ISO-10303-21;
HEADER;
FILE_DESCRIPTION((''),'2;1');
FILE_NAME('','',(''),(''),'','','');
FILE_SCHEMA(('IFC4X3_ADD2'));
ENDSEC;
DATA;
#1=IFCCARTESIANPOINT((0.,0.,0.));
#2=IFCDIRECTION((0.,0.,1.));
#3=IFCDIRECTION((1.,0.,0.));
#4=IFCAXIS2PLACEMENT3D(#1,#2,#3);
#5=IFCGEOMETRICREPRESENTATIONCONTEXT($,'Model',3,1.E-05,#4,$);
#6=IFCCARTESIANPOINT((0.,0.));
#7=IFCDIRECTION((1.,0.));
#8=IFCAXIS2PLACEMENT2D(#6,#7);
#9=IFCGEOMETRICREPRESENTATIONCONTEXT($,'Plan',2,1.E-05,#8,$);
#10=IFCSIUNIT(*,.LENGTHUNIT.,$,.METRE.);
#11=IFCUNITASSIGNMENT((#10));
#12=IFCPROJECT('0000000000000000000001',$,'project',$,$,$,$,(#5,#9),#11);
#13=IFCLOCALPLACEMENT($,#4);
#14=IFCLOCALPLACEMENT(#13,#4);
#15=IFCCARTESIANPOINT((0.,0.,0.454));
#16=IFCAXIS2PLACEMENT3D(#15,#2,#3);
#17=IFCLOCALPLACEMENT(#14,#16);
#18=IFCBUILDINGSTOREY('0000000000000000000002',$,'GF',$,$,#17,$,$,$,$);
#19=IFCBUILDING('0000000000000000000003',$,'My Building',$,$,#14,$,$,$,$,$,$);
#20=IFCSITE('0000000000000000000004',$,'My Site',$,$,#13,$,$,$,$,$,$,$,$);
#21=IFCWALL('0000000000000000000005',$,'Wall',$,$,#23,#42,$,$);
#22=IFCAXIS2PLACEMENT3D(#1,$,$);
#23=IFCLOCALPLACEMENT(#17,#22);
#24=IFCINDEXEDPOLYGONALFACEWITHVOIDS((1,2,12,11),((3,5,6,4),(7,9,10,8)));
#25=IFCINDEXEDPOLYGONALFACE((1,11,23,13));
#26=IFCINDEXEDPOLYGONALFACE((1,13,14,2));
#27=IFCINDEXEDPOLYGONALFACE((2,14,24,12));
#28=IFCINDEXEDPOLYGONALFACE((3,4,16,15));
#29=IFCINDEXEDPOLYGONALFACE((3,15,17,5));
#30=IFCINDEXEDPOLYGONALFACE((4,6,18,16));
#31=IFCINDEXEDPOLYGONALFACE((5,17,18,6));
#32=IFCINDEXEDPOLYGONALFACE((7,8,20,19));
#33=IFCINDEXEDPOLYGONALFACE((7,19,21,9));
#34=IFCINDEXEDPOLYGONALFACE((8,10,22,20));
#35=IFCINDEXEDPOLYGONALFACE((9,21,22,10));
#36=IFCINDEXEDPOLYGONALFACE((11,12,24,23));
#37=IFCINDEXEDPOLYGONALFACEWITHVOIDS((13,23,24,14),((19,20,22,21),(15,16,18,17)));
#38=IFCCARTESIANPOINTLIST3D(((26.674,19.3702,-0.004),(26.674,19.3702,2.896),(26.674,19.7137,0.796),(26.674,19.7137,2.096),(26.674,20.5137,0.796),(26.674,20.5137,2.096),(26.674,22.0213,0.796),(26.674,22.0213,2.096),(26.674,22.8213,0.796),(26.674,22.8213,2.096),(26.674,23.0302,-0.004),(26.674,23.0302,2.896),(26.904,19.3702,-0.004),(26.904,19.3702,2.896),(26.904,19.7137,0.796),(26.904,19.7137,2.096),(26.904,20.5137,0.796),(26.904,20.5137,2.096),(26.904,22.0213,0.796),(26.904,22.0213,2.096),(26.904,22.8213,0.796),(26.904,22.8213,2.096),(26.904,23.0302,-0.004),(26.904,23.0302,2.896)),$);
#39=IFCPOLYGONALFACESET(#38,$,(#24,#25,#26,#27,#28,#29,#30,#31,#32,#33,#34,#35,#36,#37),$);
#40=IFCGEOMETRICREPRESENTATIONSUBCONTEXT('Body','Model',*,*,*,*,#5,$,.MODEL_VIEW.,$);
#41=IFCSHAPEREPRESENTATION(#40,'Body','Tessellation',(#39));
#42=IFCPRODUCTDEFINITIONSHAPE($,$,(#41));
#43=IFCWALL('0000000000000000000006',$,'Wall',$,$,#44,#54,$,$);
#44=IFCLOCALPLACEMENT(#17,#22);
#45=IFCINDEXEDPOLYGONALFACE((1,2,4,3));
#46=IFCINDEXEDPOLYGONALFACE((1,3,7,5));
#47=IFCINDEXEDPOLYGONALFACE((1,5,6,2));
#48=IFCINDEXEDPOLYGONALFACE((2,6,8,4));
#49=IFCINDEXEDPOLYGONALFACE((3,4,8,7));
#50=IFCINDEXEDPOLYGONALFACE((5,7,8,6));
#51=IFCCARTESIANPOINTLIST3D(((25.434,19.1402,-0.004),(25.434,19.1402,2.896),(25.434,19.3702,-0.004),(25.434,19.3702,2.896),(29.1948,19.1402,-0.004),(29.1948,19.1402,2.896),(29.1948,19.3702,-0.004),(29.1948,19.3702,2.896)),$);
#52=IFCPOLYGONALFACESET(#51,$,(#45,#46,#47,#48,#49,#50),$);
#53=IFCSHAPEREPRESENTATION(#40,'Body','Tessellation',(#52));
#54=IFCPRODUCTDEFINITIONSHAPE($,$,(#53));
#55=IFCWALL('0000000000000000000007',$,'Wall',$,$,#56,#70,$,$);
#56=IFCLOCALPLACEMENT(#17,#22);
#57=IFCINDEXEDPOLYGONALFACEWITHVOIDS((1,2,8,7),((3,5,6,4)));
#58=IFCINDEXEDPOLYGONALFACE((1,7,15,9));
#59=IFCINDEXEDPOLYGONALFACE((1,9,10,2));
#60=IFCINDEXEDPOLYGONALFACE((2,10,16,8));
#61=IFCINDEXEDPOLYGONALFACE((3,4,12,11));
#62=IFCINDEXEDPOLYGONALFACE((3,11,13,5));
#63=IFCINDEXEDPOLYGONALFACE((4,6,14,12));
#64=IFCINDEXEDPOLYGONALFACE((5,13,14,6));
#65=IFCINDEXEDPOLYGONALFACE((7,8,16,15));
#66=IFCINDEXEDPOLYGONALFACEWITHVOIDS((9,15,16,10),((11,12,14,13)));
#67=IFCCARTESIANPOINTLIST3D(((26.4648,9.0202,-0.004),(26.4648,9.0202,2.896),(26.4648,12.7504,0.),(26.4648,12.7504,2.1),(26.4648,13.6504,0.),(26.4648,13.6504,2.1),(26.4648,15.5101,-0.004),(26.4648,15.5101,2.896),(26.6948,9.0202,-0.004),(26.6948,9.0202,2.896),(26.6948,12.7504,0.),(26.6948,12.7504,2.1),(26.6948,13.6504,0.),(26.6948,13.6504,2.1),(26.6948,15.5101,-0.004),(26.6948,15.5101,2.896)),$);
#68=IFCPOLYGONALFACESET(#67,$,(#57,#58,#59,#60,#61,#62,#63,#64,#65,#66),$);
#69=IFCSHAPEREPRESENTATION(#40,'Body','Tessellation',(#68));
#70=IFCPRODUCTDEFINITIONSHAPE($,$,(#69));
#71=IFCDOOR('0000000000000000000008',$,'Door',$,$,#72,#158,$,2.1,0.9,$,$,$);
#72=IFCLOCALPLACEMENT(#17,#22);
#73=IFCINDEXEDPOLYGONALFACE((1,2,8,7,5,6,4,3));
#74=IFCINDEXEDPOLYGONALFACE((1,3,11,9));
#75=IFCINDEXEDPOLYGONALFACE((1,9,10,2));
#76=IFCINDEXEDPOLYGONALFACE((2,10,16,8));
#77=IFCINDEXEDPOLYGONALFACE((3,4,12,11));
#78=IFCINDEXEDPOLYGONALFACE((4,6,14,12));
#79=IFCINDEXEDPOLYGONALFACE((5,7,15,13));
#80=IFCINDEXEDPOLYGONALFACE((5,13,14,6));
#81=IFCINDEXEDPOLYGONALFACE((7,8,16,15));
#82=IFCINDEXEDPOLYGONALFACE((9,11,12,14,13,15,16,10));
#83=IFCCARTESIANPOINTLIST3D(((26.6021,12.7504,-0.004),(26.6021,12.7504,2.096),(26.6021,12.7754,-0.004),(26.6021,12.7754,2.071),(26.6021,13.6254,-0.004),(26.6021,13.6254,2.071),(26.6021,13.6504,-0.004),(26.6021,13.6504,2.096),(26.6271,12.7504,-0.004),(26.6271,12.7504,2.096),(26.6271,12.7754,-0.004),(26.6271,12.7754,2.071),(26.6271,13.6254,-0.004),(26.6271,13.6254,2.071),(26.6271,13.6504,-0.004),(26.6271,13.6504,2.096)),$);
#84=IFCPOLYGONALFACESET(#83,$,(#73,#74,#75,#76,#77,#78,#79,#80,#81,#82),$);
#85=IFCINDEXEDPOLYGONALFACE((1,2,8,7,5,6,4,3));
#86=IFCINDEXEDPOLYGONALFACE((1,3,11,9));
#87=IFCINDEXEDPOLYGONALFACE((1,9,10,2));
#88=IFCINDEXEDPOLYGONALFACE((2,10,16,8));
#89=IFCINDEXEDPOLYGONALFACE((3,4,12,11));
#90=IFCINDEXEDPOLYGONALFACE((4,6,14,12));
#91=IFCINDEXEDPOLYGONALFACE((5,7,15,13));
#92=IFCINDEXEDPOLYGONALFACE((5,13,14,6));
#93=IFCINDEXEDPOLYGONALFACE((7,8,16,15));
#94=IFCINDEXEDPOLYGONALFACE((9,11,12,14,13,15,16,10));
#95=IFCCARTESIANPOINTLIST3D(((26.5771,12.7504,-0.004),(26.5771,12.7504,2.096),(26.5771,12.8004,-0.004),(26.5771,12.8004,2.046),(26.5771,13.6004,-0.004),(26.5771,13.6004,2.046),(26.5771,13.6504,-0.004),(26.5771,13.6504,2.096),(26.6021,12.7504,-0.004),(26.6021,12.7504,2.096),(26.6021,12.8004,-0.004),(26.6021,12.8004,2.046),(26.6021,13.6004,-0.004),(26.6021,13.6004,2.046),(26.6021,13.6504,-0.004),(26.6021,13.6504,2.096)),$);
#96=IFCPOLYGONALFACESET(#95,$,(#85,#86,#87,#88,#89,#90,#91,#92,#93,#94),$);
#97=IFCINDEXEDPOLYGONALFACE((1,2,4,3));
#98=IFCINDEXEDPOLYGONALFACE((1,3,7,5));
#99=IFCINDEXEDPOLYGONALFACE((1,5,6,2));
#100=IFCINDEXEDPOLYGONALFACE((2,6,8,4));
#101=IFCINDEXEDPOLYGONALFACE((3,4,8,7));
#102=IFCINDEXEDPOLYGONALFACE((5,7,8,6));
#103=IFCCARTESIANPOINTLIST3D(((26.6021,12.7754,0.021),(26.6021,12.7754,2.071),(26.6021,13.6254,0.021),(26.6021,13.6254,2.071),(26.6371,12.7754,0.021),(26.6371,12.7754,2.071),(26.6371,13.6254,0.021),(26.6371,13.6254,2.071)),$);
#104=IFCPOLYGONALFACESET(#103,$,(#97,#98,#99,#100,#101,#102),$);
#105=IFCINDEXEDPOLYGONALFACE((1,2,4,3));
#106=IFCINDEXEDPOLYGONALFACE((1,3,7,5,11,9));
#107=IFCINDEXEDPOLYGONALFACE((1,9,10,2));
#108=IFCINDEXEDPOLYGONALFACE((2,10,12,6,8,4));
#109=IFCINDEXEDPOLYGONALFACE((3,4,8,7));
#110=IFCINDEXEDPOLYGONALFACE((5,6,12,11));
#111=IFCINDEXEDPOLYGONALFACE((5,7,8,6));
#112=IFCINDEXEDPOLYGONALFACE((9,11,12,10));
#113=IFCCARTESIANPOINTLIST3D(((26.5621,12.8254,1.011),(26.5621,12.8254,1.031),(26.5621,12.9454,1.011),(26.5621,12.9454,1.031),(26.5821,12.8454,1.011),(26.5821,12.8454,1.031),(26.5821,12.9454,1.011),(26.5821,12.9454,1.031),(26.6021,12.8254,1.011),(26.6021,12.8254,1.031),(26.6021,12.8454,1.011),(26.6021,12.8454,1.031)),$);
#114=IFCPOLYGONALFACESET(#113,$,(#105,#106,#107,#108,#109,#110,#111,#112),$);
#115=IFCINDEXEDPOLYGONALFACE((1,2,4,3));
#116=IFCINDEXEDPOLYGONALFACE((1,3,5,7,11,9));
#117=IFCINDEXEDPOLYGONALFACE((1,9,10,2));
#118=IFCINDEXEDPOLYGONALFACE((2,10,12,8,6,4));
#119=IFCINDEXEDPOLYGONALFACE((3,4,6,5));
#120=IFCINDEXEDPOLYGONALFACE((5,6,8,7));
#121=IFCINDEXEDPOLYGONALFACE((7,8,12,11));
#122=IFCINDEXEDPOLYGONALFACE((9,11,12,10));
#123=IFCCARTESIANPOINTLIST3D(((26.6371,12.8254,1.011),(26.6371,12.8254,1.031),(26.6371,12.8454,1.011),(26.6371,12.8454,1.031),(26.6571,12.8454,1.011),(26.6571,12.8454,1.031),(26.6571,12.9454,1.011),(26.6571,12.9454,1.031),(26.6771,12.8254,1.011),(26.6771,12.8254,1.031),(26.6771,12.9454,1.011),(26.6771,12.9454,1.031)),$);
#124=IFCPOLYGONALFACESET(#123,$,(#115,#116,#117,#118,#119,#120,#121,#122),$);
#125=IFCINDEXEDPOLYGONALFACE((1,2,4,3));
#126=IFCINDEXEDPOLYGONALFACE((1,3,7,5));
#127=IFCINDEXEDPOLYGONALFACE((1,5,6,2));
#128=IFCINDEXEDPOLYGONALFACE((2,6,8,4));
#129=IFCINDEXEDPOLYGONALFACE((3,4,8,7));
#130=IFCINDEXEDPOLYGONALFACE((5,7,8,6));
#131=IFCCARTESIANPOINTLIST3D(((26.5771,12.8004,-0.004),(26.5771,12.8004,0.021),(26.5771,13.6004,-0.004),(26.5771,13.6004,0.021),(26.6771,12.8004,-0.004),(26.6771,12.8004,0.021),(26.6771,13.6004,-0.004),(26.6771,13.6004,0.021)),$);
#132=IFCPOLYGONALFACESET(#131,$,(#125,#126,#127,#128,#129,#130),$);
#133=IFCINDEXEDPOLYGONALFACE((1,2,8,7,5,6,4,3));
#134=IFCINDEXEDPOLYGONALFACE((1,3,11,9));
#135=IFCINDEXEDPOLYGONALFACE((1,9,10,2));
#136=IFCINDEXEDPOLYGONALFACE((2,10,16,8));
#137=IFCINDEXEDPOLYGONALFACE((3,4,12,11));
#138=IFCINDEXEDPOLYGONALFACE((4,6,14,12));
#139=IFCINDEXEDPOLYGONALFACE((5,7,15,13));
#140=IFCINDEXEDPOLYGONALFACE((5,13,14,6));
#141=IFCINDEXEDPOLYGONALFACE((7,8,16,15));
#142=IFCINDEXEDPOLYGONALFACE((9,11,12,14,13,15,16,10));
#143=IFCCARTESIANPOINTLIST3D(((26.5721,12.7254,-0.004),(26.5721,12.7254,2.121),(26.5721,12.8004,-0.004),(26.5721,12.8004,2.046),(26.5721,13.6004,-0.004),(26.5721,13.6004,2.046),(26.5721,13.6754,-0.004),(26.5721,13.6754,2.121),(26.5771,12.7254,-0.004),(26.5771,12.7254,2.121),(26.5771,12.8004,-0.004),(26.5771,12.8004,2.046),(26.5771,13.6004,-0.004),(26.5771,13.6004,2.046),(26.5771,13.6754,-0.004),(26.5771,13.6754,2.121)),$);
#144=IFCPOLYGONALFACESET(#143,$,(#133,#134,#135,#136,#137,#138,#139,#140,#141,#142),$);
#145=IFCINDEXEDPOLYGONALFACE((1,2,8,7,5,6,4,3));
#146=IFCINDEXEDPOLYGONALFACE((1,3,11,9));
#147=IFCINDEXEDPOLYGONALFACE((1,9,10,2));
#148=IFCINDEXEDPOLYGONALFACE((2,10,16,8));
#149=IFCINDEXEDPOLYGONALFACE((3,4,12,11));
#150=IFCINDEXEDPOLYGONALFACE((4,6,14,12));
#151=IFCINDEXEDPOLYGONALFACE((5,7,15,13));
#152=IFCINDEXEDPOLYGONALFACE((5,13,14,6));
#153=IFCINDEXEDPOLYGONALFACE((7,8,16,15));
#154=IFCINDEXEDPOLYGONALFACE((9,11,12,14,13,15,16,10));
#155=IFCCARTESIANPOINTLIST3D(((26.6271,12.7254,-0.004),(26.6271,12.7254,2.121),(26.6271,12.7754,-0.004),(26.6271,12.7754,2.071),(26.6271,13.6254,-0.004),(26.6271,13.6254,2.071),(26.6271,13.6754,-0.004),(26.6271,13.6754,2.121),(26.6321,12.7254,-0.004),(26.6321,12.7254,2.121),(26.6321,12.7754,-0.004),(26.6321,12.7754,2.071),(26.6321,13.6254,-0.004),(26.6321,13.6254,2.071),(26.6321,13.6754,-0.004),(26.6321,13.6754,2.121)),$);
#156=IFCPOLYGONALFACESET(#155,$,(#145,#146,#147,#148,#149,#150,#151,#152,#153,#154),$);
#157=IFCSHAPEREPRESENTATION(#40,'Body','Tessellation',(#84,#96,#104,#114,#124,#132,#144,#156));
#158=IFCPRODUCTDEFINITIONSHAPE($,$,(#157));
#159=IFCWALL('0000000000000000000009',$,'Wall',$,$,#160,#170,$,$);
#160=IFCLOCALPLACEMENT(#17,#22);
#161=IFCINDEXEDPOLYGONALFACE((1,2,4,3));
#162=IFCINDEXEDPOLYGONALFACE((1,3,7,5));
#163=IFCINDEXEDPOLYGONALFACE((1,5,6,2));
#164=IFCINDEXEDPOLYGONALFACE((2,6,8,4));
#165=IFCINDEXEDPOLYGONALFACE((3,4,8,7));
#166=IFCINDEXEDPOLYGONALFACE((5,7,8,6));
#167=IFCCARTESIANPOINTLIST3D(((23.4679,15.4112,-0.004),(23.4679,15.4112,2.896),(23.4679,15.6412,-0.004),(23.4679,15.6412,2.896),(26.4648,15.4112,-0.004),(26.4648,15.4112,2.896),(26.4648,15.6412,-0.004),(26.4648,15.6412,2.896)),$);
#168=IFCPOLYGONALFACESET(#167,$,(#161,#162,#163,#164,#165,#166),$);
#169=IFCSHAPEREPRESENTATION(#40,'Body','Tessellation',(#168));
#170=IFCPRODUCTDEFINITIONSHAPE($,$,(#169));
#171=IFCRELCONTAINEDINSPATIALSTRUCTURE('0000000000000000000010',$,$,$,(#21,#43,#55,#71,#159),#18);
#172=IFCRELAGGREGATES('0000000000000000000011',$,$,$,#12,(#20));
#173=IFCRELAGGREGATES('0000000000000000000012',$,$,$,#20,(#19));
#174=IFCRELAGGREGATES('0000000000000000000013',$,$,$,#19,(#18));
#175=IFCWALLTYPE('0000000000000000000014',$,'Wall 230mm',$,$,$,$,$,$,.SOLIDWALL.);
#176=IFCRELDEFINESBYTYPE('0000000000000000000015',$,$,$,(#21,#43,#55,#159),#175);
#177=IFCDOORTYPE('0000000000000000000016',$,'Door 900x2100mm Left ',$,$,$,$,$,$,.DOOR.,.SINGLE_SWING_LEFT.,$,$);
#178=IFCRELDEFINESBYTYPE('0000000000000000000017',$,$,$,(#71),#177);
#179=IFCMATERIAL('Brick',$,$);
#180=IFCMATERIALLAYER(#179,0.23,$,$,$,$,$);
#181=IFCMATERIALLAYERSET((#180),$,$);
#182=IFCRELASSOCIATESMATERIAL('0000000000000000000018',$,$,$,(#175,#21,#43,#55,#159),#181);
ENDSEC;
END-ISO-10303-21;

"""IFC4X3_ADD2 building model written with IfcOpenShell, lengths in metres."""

from ifc_helpers import new_model, entity, si_unit, frame, origin_with_axes, origin_2d_with_axis, place, context, subcontext, project, spatial, line, indexed_curve, outline, extrude, shape, source, transform, mapped, material, layer, layer_set, layer_usage, type_object, type_shapes, element, fill, save


model = new_model("IFC4X3_ADD2")

# Units and contexts
model_context = context("Model", 3, precision=1e-05, world=origin_with_axes())
plan_context = context("Plan", 2, precision=1e-05, world=origin_2d_with_axis())
body_context_1 = subcontext(model_context, "Body", "Model", "MODEL_VIEW")
body_context_2 = subcontext(plan_context, "Body", "Plan", "PLAN_VIEW")
ifc_project = project(units=[si_unit("LENGTHUNIT", "METRE")], contexts=[model_context, plan_context])

# Site, building, storey
site_placement = place(None, origin_with_axes())
site = spatial("IfcSite", under=ifc_project, at=site_placement, Name="My Site")
building_placement = place(site_placement, origin_with_axes())
building = spatial("IfcBuilding", under=site, at=building_placement, Name="My Building")
storey_placement = place(building_placement, frame((0.0, 0.0, 0.454), z_axis=(0.0, 0.0, 1.0), x_axis=(1.0, 0.0, 0.0)))
storey = spatial("IfcBuildingStorey", under=building, at=storey_placement, Name="GF")

# Shared definitions
ifc_material_1 = material(Name="Brick")

# Shared definitions
shared_shape_1 = source(origin_with_axes(), body_context_1, "Body", "SweptSolid", [
    extrude(outline(indexed_curve([(0.0, 0.0), (0.9, 0.0), (0.9, 2.1), (0.0, 2.1)], segments=[line(1, 2, 3, 4, 1)])), frame((0.0, -0.6, 0.0), z_axis=(0.0, -1.0, 0.0), x_axis=(1.0, 0.0, 0.0)), (0.0, 0.0, -1.0), 1.2),
])
door_type = type_object("IfcDoorType", Name="Door 900x2100mm Left ", OperationType="SINGLE_SWING_LEFT", PredefinedType="DOOR")
shared_shape_2 = source(origin_with_axes(), body_context_1, "Body", "SweptSolid", [
    extrude(outline(indexed_curve([(0.0, 0.0), (0.0, 2.1), (0.9, 2.1), (0.9, 0.0), (0.875, 0.0), (0.875, 2.075), (0.025, 2.075), (0.025, 0.0)], segments=[line(1, 2, 3, 4, 5, 6, 7, 8, 1)])), frame((0.0, 0.025, 0.0), z_axis=(0.0, -1.0, 0.0), x_axis=(1.0, 0.0, 0.0)), (0.0, 0.0, -1.0), 0.025),
    extrude(outline(indexed_curve([(0.0, 0.0), (0.0, 2.1), (0.9, 2.1), (0.9, 0.0), (0.85, 0.0), (0.85, 2.05), (0.05, 2.05), (0.05, 0.0)], segments=[line(1, 2, 3, 4, 5, 6, 7, 8, 1)])), frame((0.0, 0.0, 0.0), z_axis=(0.0, -1.0, 0.0), x_axis=(1.0, 0.0, 0.0)), (0.0, 0.0, -1.0), 0.025),
    extrude(outline(indexed_curve([(0.0, 0.0), (0.85, 0.0), (0.85, 0.035), (0.0, 0.035)], segments=[line(1, 2, 3, 4, 1)])), frame((0.025, 0.025, 0.025), z_axis=(0.0, 0.0, 1.0), x_axis=(1.0, 0.0, 0.0)), (0.0, 0.0, 1.0), 2.05),
    extrude(outline(indexed_curve([(0.0, 0.0), (0.0, -0.04), (-0.12, -0.04), (-0.12, -0.02), (-0.02, -0.02), (-0.02, 0.0)], segments=[line(1, 2, 3, 4, 5, 6, 1)])), frame((0.825, 0.025, 1.015), z_axis=(0.0, 0.0, 1.0), x_axis=(1.0, 0.0, 0.0)), (0.0, 0.0, 1.0), 0.02),
    extrude(outline(indexed_curve([(0.0, 0.0), (0.0, 0.04), (-0.12, 0.04), (-0.12, 0.02), (-0.02, 0.02), (-0.02, 0.0)], segments=[line(1, 2, 3, 4, 5, 6, 1)])), frame((0.825, 0.06, 1.015), z_axis=(0.0, 0.0, 1.0), x_axis=(1.0, 0.0, 0.0)), (0.0, 0.0, 1.0), 0.02),
    extrude(outline(indexed_curve([(0.0, 0.0), (0.8, 0.0), (0.8, 0.1), (0.0, 0.1)], segments=[line(1, 2, 3, 4, 1)])), frame((0.05, 0.0, 0.0), z_axis=(0.0, 0.0, 1.0), x_axis=(1.0, 0.0, 0.0)), (0.0, 0.0, 1.0), 0.025),
    extrude(outline(indexed_curve([(0.0, 0.0), (0.0, 2.125), (0.95, 2.125), (0.95, 0.0), (0.875, 0.0), (0.875, 2.05), (0.075, 2.05), (0.075, 0.0)], segments=[line(1, 2, 3, 4, 5, 6, 7, 8, 1)])), frame((-0.025, -0.005, 0.0), z_axis=(0.0, -1.0, 0.0), x_axis=(1.0, 0.0, 0.0)), (0.0, 0.0, -1.0), 0.005),
    extrude(outline(indexed_curve([(0.0, 0.0), (0.0, 2.125), (0.95, 2.125), (0.95, 0.0), (0.9, 0.0), (0.9, 2.075), (0.05, 2.075), (0.05, 0.0)], segments=[line(1, 2, 3, 4, 5, 6, 7, 8, 1)])), frame((-0.025, 0.05, 0.0), z_axis=(0.0, -1.0, 0.0), x_axis=(1.0, 0.0, 0.0)), (0.0, 0.0, -1.0), 0.005),
])
shared_shape_3 = source(origin_with_axes(), body_context_2, "Body", "Curve2D", [
    entity("IfcIndexedPolyCurve", entity("IfcCartesianPointList2D", [[0.0, 0.0], [0.0, 0.05], [0.025, 0.05], [0.025, 0.025], [0.05, 0.025], [0.05, 0.0]]), [entity("IfcLineIndex", [1, 2, 3, 4, 5, 6, 1])]),
    entity("IfcIndexedPolyCurve", entity("IfcCartesianPointList2D", [[0.9, 0.0], [0.9, 0.05], [0.875, 0.05], [0.875, 0.025], [0.85, 0.025], [0.85, 0.0]]), [entity("IfcLineIndex", [1, 2, 3, 4, 5, 6, 1])]),
    entity("IfcTrimmedCurve", entity("IfcEllipse", entity("IfcAxis2Placement2D", entity("IfcCartesianPoint", [0.06, 0.05]), entity("IfcDirection", [1.0, 0.0])), 0.815, 0.85), [entity("IfcCartesianPoint", [0.875, 0.05])], [entity("IfcCartesianPoint", [0.06, 0.9])], True, "CARTESIAN"),
    entity("IfcIndexedPolyCurve", entity("IfcCartesianPointList2D", [[0.025, 0.05], [0.06, 0.05], [0.06, 0.9], [0.025, 0.9]]), [entity("IfcLineIndex", [1, 2, 3, 4, 1])]),
])
type_shapes(door_type, [shared_shape_2, shared_shape_3])

# Wall, openings
ifc_layer_1 = layer(ifc_material_1, 0.23)
ifc_layer_set_1 = layer_set([ifc_layer_1])
wall_type_1 = type_object("IfcWallType", Name="Wall 230mm", PredefinedType="SOLIDWALL", material=ifc_layer_set_1)
ifc_layer_usage_1 = layer_usage(ifc_layer_set_1, "AXIS2", "POSITIVE", 0.0)
wall_1_placement = place(storey_placement, frame((26.904, 19.3702, -0.004), z_axis=(0.0, 0.0, 1.0), x_axis=(0.000001, 1.0, 0.0)))
wall_1 = element("IfcWall", 1, at=wall_1_placement, inside=storey, type_object=wall_type_1, material=ifc_layer_usage_1, Name="Wall", context=body_context_1, shape_type="SweptSolid", body=[
    extrude(outline(indexed_curve([(0.0, 0.0), (0.0, 0.23), (3.66, 0.23), (3.66, 0.0), (0.0, 0.0)], self_intersect=False)), origin_with_axes(), (0.0, 0.0, 1.0), 2.9),
])
shared_shape_4 = source(origin_with_axes(), body_context_1, "Body", "SweptSolid", [
    extrude(outline(indexed_curve([(0.0, 0.0), (0.8, 0.0), (0.8, 1.3), (0.0, 1.3)], segments=[line(1, 2, 3, 4, 1)])), frame((-0.4, -0.6, 0.0), z_axis=(0.0, -1.0, 0.0), x_axis=(1.0, 0.0, 0.0)), (0.0, 0.0, -1.0), 1.2),
])
opening_1_placement = place(wall_1_placement, frame((0.7435, 0.0, 0.8), z_axis=(0.0, 0.0, 1.0), x_axis=(1.0, 0.0, 0.0)))
element("IfcOpeningElement", 2, at=opening_1_placement, cuts=wall_1, PredefinedType="OPENING", context=body_context_1, shape_type="MappedRepresentation", body=[
    mapped(shared_shape_4, transform((0.0, 0.0, 0.0), x_axis=(1.0, 0.0, 0.0), y_axis=(0.0, 1.0, 0.0), z_axis=(0.0, 0.0, 1.0), scale=1.0)),
])
opening_2_placement = place(wall_1_placement, frame((3.0511, 0.0, 0.8), z_axis=(0.0, 0.0, 1.0), x_axis=(1.0, 0.0, 0.0)))
element("IfcOpeningElement", 3, at=opening_2_placement, cuts=wall_1, PredefinedType="OPENING", context=body_context_1, shape_type="MappedRepresentation", body=[
    mapped(shared_shape_4, transform((0.0, 0.0, 0.0), x_axis=(1.0, 0.0, 0.0), y_axis=(0.0, 1.0, 0.0), z_axis=(0.0, 0.0, 1.0), scale=1.0)),
])

# Wall
ifc_layer_usage_2 = layer_usage(ifc_layer_set_1, "AXIS2", "POSITIVE", 0.0)
wall_2_placement = place(storey_placement, frame((29.1948, 19.3702, -0.004), z_axis=(0.0, 0.0, 1.0), x_axis=(-1.0, 0.0, 0.0)))
element("IfcWall", 4, at=wall_2_placement, inside=storey, type_object=wall_type_1, material=ifc_layer_usage_2, Name="Wall", context=body_context_1, shape_type="SweptSolid", body=[
    extrude(outline(indexed_curve([(0.0, 0.0), (0.0, 0.23), (3.7608, 0.23), (3.7608, 0.0), (0.0, 0.0)], self_intersect=False)), origin_with_axes(), (0.0, 0.0, 1.0), 2.9),
])

# Wall, opening, door
ifc_layer_usage_3 = layer_usage(ifc_layer_set_1, "AXIS2", "POSITIVE", 0.0)
wall_3_placement = place(storey_placement, frame((26.6948, 9.0202, -0.004), z_axis=(0.0, 0.0, 1.0), x_axis=(0.000001, 1.0, 0.0)))
wall_3 = element("IfcWall", 5, at=wall_3_placement, inside=storey, type_object=wall_type_1, material=ifc_layer_usage_3, Name="Wall", context=body_context_1, shape_type="SweptSolid", body=[
    extrude(outline(indexed_curve([(0.0, 0.0), (0.0, 0.23), (6.4899, 0.23), (6.4899, 0.0), (0.0, 0.0)], self_intersect=False)), origin_with_axes(), (0.0, 0.0, 1.0), 2.9),
])
opening_3_placement = place(wall_3_placement, frame((4.6302, 0.1177, 0.004), z_axis=(0.0, 0.0, 1.0), x_axis=(-1.0, 0.0, 0.0)))
opening_3 = element("IfcOpeningElement", 6, at=opening_3_placement, cuts=wall_3, PredefinedType="OPENING", context=body_context_1, shape_type="MappedRepresentation", body=[
    mapped(shared_shape_1, transform((0.0, 0.0, 0.0), x_axis=(1.0, 0.0, 0.0), y_axis=(0.0, 1.0, 0.0), z_axis=(0.0, 0.0, 1.0), scale=1.0)),
])
door_1_placement = place(opening_3_placement, frame((0.0, 0.0, -0.004), z_axis=(0.0, 0.0, 1.0), x_axis=(1.0, 0.0, 0.0)))
door_1 = element("IfcDoor", 7, at=door_1_placement, inside=storey, type_object=door_type, Name="Door", OverallHeight=2.1, OverallWidth=0.9, shapes=[
    shape(body_context_1, "Body", "MappedRepresentation", [mapped(shared_shape_2, transform((0.0, 0.0, 0.0), x_axis=(1.0, 0.0, 0.0), y_axis=(0.0, 1.0, 0.0), z_axis=(0.0, 0.0, 1.0), scale=1.0))]),
    shape(body_context_2, "Body", "MappedRepresentation", [mapped(shared_shape_3, transform((0.0, 0.0, 0.0), x_axis=(1.0, 0.0, 0.0), y_axis=(0.0, 1.0, 0.0), z_axis=(0.0, 0.0, 1.0), scale=1.0))]),
])
fill(opening_3, door_1)

# Wall
ifc_layer_usage_4 = layer_usage(ifc_layer_set_1, "AXIS2", "POSITIVE", 0.0)
wall_4_placement = place(storey_placement, frame((26.4648, 15.6412, -0.004), z_axis=(0.0, 0.0, 1.0), x_axis=(-1.0, 0.0, 0.0)))
element("IfcWall", 8, at=wall_4_placement, inside=storey, type_object=wall_type_1, material=ifc_layer_usage_4, Name="Wall", context=body_context_1, shape_type="SweptSolid", body=[
    extrude(outline(indexed_curve([(0.0, 0.0), (0.0, 0.23), (2.9969, 0.23), (2.9969, 0.0), (0.0, 0.0)], self_intersect=False)), origin_with_axes(), (0.0, 0.0, 1.0), 2.9),
])

save(model, "model.ifc")
